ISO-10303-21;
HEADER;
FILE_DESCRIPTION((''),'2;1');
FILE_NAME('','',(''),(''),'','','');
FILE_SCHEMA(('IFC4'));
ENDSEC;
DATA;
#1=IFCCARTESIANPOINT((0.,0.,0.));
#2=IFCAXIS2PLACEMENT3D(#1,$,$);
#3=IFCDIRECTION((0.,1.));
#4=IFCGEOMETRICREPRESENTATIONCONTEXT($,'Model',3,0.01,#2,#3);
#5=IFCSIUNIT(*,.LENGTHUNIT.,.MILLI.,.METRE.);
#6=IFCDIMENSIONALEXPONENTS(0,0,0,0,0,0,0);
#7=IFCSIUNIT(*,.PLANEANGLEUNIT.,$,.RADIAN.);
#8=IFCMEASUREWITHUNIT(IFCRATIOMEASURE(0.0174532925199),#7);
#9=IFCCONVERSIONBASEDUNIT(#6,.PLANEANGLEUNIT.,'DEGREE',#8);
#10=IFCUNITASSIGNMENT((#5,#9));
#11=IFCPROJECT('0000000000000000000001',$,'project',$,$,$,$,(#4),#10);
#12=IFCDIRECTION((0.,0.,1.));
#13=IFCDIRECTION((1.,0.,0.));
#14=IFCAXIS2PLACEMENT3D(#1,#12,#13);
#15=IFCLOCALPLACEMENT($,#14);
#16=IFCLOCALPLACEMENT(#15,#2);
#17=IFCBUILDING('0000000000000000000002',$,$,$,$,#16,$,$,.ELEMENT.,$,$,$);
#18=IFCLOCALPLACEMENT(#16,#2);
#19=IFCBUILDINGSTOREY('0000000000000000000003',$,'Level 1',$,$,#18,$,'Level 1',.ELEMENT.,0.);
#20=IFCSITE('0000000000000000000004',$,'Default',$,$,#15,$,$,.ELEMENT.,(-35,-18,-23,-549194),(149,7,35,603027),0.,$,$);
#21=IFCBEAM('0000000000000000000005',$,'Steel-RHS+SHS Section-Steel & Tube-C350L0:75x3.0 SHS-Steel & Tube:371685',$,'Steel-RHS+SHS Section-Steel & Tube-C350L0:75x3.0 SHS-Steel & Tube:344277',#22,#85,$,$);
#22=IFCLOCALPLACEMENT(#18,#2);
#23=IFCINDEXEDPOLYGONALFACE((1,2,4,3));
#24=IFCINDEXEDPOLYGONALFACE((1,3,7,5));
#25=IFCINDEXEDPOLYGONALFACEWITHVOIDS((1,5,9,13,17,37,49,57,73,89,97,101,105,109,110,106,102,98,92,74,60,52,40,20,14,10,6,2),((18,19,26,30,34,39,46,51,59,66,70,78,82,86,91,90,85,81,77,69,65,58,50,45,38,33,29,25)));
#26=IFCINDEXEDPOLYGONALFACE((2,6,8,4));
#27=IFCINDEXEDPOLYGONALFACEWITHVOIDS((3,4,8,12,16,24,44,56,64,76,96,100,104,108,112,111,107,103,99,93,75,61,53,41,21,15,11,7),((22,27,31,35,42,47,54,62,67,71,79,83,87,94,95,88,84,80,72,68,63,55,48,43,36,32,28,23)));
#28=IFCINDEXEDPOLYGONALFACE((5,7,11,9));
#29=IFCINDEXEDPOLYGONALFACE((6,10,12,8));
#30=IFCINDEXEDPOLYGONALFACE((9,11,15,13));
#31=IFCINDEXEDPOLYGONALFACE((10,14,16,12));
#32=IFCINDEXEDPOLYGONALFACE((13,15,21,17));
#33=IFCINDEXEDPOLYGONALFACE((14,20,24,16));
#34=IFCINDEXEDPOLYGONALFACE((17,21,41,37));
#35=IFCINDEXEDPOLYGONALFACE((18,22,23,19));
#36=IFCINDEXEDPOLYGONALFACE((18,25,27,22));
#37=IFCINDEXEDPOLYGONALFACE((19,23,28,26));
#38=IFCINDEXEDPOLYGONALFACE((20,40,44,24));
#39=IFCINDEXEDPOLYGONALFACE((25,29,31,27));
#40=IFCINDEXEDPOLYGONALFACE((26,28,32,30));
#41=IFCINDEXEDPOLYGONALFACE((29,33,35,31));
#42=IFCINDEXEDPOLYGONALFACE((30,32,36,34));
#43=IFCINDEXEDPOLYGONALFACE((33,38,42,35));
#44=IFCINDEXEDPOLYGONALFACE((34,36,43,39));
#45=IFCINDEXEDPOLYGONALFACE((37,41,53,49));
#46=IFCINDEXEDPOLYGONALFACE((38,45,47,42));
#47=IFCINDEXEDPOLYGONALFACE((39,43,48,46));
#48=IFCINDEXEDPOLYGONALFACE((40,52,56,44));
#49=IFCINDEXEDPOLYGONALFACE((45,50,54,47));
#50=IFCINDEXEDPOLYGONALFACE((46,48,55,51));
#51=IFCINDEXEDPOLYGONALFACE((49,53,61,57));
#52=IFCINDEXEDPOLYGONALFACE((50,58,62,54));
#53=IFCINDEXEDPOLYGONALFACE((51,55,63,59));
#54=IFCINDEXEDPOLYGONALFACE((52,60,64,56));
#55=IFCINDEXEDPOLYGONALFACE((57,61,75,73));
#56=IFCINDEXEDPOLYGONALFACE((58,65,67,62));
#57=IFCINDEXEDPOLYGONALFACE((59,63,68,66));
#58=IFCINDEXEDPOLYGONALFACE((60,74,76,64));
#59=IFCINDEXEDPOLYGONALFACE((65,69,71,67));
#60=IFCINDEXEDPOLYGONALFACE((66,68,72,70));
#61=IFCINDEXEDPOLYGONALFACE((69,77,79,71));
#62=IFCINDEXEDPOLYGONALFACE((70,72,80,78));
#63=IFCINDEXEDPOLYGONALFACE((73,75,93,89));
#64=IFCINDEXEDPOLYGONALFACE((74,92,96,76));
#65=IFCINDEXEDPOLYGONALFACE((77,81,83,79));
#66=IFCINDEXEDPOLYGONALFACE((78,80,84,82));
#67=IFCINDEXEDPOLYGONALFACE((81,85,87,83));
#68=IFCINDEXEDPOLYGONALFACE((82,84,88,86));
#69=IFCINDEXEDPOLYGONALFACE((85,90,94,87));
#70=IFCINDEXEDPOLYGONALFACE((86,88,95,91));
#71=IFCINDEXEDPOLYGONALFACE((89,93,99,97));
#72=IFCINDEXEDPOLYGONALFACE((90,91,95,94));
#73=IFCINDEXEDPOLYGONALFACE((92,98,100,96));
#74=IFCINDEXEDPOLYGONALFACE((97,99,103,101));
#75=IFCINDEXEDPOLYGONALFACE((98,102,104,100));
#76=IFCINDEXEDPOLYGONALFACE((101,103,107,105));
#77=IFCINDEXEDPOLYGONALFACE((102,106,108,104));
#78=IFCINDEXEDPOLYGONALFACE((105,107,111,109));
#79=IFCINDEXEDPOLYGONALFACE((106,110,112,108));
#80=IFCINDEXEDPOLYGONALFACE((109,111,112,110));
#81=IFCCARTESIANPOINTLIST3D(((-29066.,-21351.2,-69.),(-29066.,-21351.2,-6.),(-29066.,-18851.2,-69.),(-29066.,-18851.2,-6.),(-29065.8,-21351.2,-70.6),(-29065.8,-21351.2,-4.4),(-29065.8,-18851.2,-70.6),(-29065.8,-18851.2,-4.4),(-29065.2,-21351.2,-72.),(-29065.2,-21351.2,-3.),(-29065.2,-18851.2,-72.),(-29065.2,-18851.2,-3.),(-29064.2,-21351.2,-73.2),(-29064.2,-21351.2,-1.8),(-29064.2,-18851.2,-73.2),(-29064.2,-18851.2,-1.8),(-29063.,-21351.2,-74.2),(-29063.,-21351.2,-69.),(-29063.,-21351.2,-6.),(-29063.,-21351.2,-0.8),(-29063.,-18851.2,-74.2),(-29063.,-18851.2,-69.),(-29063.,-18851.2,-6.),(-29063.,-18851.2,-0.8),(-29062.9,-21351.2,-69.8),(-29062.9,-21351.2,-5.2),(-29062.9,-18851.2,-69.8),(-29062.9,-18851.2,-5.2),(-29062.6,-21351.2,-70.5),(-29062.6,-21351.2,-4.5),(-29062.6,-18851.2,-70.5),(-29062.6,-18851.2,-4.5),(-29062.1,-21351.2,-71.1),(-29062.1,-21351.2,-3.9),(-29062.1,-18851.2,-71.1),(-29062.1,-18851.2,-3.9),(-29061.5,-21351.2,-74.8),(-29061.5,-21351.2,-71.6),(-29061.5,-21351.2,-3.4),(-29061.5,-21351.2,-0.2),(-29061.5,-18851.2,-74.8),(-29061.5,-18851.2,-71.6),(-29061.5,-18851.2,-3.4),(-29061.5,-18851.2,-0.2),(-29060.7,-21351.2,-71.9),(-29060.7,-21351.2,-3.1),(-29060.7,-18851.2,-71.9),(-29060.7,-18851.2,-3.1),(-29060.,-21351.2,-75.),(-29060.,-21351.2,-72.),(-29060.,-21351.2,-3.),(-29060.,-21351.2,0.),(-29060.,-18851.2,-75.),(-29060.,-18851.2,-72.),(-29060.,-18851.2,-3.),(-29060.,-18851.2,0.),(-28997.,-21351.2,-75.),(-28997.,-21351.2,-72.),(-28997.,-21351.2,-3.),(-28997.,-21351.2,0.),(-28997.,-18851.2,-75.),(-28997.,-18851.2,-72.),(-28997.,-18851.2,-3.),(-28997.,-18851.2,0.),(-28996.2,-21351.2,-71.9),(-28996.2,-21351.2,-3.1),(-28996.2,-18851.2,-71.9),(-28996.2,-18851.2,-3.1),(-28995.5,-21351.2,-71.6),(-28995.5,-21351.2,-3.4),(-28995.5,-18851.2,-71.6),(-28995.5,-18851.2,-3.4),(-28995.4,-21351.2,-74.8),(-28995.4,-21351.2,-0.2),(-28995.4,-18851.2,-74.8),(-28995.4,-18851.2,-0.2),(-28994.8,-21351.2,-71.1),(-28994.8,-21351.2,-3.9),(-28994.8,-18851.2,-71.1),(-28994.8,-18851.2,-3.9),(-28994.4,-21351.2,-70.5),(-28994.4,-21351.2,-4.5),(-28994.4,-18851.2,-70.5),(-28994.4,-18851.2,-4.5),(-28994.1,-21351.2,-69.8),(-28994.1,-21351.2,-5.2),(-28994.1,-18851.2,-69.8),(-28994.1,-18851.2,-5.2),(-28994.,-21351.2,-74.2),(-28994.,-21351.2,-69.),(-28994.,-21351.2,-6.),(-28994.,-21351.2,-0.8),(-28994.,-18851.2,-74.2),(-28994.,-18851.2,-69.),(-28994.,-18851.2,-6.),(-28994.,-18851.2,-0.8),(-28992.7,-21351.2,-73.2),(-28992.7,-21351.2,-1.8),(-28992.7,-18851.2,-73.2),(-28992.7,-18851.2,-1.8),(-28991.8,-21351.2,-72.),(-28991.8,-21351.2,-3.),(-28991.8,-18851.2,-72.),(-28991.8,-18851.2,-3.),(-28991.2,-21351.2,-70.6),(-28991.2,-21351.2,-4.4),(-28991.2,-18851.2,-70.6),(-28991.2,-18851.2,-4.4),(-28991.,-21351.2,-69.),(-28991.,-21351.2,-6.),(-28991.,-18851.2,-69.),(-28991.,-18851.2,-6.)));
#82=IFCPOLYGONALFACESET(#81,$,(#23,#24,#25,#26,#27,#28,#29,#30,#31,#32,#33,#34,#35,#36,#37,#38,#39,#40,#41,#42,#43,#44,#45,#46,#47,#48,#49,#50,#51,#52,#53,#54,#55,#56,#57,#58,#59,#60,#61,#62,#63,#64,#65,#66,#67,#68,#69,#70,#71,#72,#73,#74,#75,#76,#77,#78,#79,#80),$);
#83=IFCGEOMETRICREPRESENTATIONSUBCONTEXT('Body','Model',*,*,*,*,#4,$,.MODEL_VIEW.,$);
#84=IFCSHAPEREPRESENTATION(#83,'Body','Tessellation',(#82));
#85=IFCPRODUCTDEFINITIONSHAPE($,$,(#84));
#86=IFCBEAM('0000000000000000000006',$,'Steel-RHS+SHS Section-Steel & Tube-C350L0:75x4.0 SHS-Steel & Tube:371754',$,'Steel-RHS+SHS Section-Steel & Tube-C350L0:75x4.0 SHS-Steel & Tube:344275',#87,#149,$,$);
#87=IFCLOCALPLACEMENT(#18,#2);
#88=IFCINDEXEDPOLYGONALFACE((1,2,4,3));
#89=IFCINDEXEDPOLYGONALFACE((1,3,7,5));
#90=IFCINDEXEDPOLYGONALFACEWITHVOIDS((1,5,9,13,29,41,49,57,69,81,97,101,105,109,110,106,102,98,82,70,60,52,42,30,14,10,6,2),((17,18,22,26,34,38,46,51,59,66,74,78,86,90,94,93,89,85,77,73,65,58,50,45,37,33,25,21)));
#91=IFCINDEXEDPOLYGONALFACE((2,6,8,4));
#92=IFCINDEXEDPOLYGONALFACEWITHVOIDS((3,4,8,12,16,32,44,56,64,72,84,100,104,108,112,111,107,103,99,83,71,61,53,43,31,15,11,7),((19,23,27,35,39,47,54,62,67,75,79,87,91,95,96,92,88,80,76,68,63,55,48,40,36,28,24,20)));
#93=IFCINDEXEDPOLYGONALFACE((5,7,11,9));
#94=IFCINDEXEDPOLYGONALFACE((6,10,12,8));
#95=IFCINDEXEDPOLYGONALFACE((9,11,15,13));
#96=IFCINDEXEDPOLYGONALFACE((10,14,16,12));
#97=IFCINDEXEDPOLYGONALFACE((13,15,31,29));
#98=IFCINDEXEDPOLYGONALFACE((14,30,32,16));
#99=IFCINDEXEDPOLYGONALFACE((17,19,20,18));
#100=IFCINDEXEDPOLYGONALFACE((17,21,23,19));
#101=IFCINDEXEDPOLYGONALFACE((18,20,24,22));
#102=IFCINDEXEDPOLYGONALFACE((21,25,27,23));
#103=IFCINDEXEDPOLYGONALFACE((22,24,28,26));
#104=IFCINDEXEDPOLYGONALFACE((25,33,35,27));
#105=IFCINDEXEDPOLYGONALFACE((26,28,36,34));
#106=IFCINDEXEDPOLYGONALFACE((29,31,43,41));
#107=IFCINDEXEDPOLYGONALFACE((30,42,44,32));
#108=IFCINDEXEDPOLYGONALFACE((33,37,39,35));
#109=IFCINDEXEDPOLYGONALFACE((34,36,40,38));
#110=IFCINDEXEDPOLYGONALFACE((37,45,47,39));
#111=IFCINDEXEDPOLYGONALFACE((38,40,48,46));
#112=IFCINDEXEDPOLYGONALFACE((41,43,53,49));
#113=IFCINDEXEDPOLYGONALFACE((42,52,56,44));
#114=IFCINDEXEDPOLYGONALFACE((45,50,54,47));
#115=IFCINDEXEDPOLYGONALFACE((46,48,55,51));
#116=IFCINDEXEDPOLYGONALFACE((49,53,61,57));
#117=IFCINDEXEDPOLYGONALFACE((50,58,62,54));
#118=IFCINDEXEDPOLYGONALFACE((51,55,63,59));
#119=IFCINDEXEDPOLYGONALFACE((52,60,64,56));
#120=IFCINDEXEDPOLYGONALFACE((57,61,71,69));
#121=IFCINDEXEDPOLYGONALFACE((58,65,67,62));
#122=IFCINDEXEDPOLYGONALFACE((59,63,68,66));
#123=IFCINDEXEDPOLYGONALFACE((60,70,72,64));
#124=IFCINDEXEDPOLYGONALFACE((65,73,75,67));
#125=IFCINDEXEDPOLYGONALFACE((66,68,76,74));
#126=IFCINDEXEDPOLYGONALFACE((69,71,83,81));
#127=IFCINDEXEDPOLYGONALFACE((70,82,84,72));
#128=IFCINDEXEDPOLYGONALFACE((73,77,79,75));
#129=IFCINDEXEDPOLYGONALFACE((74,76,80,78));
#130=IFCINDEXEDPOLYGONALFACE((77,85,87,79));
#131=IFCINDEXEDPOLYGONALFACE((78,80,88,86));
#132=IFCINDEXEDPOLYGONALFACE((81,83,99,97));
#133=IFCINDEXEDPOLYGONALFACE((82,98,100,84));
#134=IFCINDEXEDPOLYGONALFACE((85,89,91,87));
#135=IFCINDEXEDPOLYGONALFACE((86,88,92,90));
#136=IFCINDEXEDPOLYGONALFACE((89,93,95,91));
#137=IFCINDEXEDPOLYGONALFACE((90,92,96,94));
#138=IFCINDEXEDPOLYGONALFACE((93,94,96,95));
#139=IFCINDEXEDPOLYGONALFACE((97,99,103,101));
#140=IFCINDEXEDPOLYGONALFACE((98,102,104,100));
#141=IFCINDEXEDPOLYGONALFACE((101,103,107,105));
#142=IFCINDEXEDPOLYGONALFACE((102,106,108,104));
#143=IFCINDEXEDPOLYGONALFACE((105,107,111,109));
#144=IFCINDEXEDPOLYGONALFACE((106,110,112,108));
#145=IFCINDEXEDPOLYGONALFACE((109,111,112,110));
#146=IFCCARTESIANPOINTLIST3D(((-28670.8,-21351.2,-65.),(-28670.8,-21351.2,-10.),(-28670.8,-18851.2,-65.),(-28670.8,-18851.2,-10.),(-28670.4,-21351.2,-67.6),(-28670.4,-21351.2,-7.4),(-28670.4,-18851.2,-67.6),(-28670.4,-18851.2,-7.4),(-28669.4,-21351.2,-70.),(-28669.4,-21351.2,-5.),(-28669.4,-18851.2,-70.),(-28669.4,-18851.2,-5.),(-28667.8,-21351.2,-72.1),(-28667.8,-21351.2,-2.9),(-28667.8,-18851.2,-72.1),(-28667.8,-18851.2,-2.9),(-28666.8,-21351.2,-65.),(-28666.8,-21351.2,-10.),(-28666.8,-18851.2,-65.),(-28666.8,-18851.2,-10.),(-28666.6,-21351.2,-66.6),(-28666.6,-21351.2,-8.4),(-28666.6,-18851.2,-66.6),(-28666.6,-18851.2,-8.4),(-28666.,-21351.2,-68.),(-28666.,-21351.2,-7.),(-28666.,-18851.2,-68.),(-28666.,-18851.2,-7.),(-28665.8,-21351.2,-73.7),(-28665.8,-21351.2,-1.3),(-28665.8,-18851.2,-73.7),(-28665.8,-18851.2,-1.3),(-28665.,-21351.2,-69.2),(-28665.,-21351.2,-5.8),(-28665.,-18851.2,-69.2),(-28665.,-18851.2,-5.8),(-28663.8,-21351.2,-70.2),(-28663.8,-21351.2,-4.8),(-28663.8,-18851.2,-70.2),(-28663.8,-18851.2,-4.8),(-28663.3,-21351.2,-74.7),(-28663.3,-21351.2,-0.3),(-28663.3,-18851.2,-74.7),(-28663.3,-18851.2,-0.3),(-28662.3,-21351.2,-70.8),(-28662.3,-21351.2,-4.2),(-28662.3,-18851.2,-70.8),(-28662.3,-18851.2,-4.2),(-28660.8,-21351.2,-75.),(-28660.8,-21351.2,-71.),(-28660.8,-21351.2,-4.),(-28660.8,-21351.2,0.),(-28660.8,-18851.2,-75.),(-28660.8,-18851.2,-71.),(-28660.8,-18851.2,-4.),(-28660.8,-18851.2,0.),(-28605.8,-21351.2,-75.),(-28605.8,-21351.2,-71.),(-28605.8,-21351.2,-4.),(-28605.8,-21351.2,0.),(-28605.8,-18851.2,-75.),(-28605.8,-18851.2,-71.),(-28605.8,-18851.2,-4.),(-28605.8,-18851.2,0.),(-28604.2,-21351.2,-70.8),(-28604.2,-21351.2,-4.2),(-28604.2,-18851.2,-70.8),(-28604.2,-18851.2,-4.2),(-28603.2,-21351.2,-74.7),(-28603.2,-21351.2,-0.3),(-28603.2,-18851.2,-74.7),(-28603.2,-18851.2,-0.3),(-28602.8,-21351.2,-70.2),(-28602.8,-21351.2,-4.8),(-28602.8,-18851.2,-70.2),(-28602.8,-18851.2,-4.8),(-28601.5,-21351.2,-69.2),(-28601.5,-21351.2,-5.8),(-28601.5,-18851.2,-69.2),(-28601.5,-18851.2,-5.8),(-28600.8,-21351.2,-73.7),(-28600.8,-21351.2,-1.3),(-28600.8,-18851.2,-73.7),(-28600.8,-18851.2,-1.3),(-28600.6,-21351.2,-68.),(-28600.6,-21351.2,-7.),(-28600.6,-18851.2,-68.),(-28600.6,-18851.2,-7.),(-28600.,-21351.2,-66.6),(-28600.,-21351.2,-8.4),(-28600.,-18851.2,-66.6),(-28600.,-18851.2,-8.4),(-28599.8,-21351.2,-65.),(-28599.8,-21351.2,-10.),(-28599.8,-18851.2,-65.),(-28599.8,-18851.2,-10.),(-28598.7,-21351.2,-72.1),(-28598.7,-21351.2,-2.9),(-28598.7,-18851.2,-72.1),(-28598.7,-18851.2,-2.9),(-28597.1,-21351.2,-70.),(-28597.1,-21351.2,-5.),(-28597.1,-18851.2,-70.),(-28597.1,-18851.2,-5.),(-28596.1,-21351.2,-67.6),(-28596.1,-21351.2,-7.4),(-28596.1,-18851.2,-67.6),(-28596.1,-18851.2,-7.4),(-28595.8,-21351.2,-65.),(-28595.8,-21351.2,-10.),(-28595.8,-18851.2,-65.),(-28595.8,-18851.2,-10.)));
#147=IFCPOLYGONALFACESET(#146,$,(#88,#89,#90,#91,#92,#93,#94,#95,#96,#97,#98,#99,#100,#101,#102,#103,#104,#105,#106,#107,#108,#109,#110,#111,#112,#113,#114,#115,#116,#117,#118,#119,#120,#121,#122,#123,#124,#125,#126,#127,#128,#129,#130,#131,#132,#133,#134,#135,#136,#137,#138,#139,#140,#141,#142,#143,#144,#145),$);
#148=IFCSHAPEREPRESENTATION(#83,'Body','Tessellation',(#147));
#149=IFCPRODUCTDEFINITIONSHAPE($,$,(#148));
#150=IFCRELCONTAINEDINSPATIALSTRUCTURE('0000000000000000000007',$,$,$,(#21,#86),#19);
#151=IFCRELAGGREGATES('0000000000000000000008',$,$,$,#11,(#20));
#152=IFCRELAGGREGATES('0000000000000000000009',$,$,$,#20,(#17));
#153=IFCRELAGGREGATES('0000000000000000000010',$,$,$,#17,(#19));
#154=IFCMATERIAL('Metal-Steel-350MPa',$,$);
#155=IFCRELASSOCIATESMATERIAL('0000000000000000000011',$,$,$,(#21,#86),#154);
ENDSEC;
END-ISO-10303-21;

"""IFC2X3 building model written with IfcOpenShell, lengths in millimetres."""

from ifc_helpers import new_model, entity, si_unit, converted_unit, direction, frame, frame_2d, origin, origin_with_axes, place, context, subcontext, project, spatial, polyline, circle_curve, parameter, trimmed, segment, composite_curve, outline, extrude, material, element, save


model = new_model("IFC2X3")

# Units and contexts
model_context = context("Model", 3, precision=0.01, world=origin(), true_north=direction((0.0, 1.0)))
body_context = subcontext(model_context, "Body", "Model", "MODEL_VIEW")
ifc_project = project(units=[si_unit("LENGTHUNIT", "METRE", prefix="MILLI"), converted_unit("PLANEANGLEUNIT", "DEGREE", entity("IfcRatioMeasure", 0.0174532925199), si_unit("PLANEANGLEUNIT", "RADIAN"), dimensions=[0, 0, 0, 0, 0, 0, 0])], contexts=[model_context])

# Site, building, storey
site_placement = place(None, origin_with_axes())
site = spatial("IfcSite", under=ifc_project, at=site_placement, Name="Default", CompositionType="ELEMENT", RefLatitude=(-35, -18, -23, -549194), RefLongitude=(149, 7, 35, 603027), RefElevation=0.0)
building_placement = place(site_placement, origin())
building = spatial("IfcBuilding", under=site, at=building_placement, CompositionType="ELEMENT")
storey_placement = place(building_placement, origin())
storey = spatial("IfcBuildingStorey", under=building, at=storey_placement, Name="Level 1", LongName="Level 1", CompositionType="ELEMENT", Elevation=0.0)

# Beams
ifc_material = material(Name="Metal-Steel-350MPa")
beam_1_placement = place(storey_placement, frame((-29028.5, -18851.2, 0.0), z_axis=(0.0, 0.0, 1.0), x_axis=(0.0, -1.0, 0.0)))
element("IfcBeam", 1, at=beam_1_placement, inside=storey, material=ifc_material, Name="Steel-RHS+SHS Section-Steel & Tube-C350L0:75x3.0 SHS-Steel & Tube:371685", ObjectType="Steel-RHS+SHS Section-Steel & Tube-C350L0:75x3.0 SHS-Steel & Tube:344277", context=body_context, shape_type="SweptSolid", body=[
    extrude(outline(composite_curve([segment(trimmed(circle_curve(frame_2d((-31.5, -31.5), x_axis=(1.0, 0.0)), 6.0), [parameter(180.0)], [parameter(270.0)], True, "PARAMETER"), True, "CONTINUOUS"), segment(polyline([(-31.5, -37.5), (31.5, -37.5)]), True, "CONTINUOUS"), segment(trimmed(circle_curve(frame_2d((31.5, -31.5), x_axis=(1.0, 0.0)), 6.0), [parameter(270.0)], [parameter(0.0)], True, "PARAMETER"), True, "CONTINUOUS"), segment(polyline([(37.5, -31.5), (37.5, 31.5)]), True, "CONTINUOUS"), segment(trimmed(circle_curve(frame_2d((31.5, 31.5), x_axis=(1.0, 0.0)), 6.0), [parameter(0.0)], [parameter(90.0)], True, "PARAMETER"), True, "CONTINUOUS"), segment(polyline([(31.5, 37.5), (-31.5, 37.5)]), True, "CONTINUOUS"), segment(trimmed(circle_curve(frame_2d((-31.5, 31.5), x_axis=(1.0, 0.0)), 6.0), [parameter(90.0)], [parameter(180.0)], True, "PARAMETER"), True, "CONTINUOUS"), segment(polyline([(-37.5, 31.5), (-37.5, -31.5)]), True, "CONTINUOUS")], self_intersect=False), holes=[composite_curve([segment(polyline([(31.5, -34.5), (-31.5, -34.5)]), True, "CONTINUOUS"), segment(trimmed(circle_curve(frame_2d((-31.5, -31.5), x_axis=(1.0, 0.0)), 3.0), [parameter(180.0)], [parameter(270.0)], True, "PARAMETER"), False, "CONTINUOUS"), segment(polyline([(-34.5, -31.5), (-34.5, 31.5)]), True, "CONTINUOUS"), segment(trimmed(circle_curve(frame_2d((-31.5, 31.5), x_axis=(1.0, 0.0)), 3.0), [parameter(90.0)], [parameter(180.0)], True, "PARAMETER"), False, "CONTINUOUS"), segment(polyline([(-31.5, 34.5), (31.5, 34.5)]), True, "CONTINUOUS"), segment(trimmed(circle_curve(frame_2d((31.5, 31.5), x_axis=(1.0, 0.0)), 3.0), [parameter(360.0)], [parameter(90.0)], True, "PARAMETER"), False, "CONTINUOUS"), segment(polyline([(34.5, 31.5), (34.5, -31.5)]), True, "CONTINUOUS"), segment(trimmed(circle_curve(frame_2d((31.5, -31.5), x_axis=(1.0, 0.0)), 3.0), [parameter(270.0)], [parameter(0.0)], True, "PARAMETER"), False, "CONTINUOUS")], self_intersect=False)]), frame((0.0, 0.0, -37.5), z_axis=(1.0, 0.0, 0.0), x_axis=(0.0, -1.0, 0.0)), (0.0, 0.0, 1.0), 2500.0),
])
beam_2_placement = place(storey_placement, frame((-28633.3, -18851.2, 0.0), z_axis=(0.0, 0.0, 1.0), x_axis=(0.0, -1.0, 0.0)))
element("IfcBeam", 2, at=beam_2_placement, inside=storey, material=ifc_material, Name="Steel-RHS+SHS Section-Steel & Tube-C350L0:75x4.0 SHS-Steel & Tube:371754", ObjectType="Steel-RHS+SHS Section-Steel & Tube-C350L0:75x4.0 SHS-Steel & Tube:344275", context=body_context, shape_type="SweptSolid", body=[
    extrude(outline(composite_curve([segment(trimmed(circle_curve(frame_2d((-27.5, -27.5), x_axis=(1.0, 0.0)), 10.0), [parameter(180.0)], [parameter(270.0)], True, "PARAMETER"), True, "CONTINUOUS"), segment(polyline([(-27.5, -37.5), (27.5, -37.5)]), True, "CONTINUOUS"), segment(trimmed(circle_curve(frame_2d((27.5, -27.5), x_axis=(1.0, 0.0)), 10.0), [parameter(270.0)], [parameter(0.0)], True, "PARAMETER"), True, "CONTINUOUS"), segment(polyline([(37.5, -27.5), (37.5, 27.5)]), True, "CONTINUOUS"), segment(trimmed(circle_curve(frame_2d((27.5, 27.5), x_axis=(1.0, 0.0)), 10.0), [parameter(0.0)], [parameter(90.0)], True, "PARAMETER"), True, "CONTINUOUS"), segment(polyline([(27.5, 37.5), (-27.5, 37.5)]), True, "CONTINUOUS"), segment(trimmed(circle_curve(frame_2d((-27.5, 27.5), x_axis=(1.0, 0.0)), 10.0), [parameter(90.0)], [parameter(180.0)], True, "PARAMETER"), True, "CONTINUOUS"), segment(polyline([(-37.5, 27.5), (-37.5, -27.5)]), True, "CONTINUOUS")], self_intersect=False), holes=[composite_curve([segment(polyline([(27.5, -33.5), (-27.5, -33.5)]), True, "CONTINUOUS"), segment(trimmed(circle_curve(frame_2d((-27.5, -27.5), x_axis=(1.0, 0.0)), 6.0), [parameter(180.0)], [parameter(270.0)], True, "PARAMETER"), False, "CONTINUOUS"), segment(polyline([(-33.5, -27.5), (-33.5, 27.5)]), True, "CONTINUOUS"), segment(trimmed(circle_curve(frame_2d((-27.5, 27.5), x_axis=(1.0, 0.0)), 6.0), [parameter(90.0)], [parameter(180.0)], True, "PARAMETER"), False, "CONTINUOUS"), segment(polyline([(-27.5, 33.5), (27.5, 33.5)]), True, "CONTINUOUS"), segment(trimmed(circle_curve(frame_2d((27.5, 27.5), x_axis=(1.0, 0.0)), 6.0), [parameter(360.0)], [parameter(90.0)], True, "PARAMETER"), False, "CONTINUOUS"), segment(polyline([(33.5, 27.5), (33.5, -27.5)]), True, "CONTINUOUS"), segment(trimmed(circle_curve(frame_2d((27.5, -27.5), x_axis=(1.0, 0.0)), 6.0), [parameter(270.0)], [parameter(0.0)], True, "PARAMETER"), False, "CONTINUOUS")], self_intersect=False)]), frame((0.0, 0.0, -37.5), z_axis=(1.0, 0.0, 0.0), x_axis=(0.0, -1.0, 0.0)), (0.0, 0.0, 1.0), 2500.0),
])

save(model, "model.ifc")
